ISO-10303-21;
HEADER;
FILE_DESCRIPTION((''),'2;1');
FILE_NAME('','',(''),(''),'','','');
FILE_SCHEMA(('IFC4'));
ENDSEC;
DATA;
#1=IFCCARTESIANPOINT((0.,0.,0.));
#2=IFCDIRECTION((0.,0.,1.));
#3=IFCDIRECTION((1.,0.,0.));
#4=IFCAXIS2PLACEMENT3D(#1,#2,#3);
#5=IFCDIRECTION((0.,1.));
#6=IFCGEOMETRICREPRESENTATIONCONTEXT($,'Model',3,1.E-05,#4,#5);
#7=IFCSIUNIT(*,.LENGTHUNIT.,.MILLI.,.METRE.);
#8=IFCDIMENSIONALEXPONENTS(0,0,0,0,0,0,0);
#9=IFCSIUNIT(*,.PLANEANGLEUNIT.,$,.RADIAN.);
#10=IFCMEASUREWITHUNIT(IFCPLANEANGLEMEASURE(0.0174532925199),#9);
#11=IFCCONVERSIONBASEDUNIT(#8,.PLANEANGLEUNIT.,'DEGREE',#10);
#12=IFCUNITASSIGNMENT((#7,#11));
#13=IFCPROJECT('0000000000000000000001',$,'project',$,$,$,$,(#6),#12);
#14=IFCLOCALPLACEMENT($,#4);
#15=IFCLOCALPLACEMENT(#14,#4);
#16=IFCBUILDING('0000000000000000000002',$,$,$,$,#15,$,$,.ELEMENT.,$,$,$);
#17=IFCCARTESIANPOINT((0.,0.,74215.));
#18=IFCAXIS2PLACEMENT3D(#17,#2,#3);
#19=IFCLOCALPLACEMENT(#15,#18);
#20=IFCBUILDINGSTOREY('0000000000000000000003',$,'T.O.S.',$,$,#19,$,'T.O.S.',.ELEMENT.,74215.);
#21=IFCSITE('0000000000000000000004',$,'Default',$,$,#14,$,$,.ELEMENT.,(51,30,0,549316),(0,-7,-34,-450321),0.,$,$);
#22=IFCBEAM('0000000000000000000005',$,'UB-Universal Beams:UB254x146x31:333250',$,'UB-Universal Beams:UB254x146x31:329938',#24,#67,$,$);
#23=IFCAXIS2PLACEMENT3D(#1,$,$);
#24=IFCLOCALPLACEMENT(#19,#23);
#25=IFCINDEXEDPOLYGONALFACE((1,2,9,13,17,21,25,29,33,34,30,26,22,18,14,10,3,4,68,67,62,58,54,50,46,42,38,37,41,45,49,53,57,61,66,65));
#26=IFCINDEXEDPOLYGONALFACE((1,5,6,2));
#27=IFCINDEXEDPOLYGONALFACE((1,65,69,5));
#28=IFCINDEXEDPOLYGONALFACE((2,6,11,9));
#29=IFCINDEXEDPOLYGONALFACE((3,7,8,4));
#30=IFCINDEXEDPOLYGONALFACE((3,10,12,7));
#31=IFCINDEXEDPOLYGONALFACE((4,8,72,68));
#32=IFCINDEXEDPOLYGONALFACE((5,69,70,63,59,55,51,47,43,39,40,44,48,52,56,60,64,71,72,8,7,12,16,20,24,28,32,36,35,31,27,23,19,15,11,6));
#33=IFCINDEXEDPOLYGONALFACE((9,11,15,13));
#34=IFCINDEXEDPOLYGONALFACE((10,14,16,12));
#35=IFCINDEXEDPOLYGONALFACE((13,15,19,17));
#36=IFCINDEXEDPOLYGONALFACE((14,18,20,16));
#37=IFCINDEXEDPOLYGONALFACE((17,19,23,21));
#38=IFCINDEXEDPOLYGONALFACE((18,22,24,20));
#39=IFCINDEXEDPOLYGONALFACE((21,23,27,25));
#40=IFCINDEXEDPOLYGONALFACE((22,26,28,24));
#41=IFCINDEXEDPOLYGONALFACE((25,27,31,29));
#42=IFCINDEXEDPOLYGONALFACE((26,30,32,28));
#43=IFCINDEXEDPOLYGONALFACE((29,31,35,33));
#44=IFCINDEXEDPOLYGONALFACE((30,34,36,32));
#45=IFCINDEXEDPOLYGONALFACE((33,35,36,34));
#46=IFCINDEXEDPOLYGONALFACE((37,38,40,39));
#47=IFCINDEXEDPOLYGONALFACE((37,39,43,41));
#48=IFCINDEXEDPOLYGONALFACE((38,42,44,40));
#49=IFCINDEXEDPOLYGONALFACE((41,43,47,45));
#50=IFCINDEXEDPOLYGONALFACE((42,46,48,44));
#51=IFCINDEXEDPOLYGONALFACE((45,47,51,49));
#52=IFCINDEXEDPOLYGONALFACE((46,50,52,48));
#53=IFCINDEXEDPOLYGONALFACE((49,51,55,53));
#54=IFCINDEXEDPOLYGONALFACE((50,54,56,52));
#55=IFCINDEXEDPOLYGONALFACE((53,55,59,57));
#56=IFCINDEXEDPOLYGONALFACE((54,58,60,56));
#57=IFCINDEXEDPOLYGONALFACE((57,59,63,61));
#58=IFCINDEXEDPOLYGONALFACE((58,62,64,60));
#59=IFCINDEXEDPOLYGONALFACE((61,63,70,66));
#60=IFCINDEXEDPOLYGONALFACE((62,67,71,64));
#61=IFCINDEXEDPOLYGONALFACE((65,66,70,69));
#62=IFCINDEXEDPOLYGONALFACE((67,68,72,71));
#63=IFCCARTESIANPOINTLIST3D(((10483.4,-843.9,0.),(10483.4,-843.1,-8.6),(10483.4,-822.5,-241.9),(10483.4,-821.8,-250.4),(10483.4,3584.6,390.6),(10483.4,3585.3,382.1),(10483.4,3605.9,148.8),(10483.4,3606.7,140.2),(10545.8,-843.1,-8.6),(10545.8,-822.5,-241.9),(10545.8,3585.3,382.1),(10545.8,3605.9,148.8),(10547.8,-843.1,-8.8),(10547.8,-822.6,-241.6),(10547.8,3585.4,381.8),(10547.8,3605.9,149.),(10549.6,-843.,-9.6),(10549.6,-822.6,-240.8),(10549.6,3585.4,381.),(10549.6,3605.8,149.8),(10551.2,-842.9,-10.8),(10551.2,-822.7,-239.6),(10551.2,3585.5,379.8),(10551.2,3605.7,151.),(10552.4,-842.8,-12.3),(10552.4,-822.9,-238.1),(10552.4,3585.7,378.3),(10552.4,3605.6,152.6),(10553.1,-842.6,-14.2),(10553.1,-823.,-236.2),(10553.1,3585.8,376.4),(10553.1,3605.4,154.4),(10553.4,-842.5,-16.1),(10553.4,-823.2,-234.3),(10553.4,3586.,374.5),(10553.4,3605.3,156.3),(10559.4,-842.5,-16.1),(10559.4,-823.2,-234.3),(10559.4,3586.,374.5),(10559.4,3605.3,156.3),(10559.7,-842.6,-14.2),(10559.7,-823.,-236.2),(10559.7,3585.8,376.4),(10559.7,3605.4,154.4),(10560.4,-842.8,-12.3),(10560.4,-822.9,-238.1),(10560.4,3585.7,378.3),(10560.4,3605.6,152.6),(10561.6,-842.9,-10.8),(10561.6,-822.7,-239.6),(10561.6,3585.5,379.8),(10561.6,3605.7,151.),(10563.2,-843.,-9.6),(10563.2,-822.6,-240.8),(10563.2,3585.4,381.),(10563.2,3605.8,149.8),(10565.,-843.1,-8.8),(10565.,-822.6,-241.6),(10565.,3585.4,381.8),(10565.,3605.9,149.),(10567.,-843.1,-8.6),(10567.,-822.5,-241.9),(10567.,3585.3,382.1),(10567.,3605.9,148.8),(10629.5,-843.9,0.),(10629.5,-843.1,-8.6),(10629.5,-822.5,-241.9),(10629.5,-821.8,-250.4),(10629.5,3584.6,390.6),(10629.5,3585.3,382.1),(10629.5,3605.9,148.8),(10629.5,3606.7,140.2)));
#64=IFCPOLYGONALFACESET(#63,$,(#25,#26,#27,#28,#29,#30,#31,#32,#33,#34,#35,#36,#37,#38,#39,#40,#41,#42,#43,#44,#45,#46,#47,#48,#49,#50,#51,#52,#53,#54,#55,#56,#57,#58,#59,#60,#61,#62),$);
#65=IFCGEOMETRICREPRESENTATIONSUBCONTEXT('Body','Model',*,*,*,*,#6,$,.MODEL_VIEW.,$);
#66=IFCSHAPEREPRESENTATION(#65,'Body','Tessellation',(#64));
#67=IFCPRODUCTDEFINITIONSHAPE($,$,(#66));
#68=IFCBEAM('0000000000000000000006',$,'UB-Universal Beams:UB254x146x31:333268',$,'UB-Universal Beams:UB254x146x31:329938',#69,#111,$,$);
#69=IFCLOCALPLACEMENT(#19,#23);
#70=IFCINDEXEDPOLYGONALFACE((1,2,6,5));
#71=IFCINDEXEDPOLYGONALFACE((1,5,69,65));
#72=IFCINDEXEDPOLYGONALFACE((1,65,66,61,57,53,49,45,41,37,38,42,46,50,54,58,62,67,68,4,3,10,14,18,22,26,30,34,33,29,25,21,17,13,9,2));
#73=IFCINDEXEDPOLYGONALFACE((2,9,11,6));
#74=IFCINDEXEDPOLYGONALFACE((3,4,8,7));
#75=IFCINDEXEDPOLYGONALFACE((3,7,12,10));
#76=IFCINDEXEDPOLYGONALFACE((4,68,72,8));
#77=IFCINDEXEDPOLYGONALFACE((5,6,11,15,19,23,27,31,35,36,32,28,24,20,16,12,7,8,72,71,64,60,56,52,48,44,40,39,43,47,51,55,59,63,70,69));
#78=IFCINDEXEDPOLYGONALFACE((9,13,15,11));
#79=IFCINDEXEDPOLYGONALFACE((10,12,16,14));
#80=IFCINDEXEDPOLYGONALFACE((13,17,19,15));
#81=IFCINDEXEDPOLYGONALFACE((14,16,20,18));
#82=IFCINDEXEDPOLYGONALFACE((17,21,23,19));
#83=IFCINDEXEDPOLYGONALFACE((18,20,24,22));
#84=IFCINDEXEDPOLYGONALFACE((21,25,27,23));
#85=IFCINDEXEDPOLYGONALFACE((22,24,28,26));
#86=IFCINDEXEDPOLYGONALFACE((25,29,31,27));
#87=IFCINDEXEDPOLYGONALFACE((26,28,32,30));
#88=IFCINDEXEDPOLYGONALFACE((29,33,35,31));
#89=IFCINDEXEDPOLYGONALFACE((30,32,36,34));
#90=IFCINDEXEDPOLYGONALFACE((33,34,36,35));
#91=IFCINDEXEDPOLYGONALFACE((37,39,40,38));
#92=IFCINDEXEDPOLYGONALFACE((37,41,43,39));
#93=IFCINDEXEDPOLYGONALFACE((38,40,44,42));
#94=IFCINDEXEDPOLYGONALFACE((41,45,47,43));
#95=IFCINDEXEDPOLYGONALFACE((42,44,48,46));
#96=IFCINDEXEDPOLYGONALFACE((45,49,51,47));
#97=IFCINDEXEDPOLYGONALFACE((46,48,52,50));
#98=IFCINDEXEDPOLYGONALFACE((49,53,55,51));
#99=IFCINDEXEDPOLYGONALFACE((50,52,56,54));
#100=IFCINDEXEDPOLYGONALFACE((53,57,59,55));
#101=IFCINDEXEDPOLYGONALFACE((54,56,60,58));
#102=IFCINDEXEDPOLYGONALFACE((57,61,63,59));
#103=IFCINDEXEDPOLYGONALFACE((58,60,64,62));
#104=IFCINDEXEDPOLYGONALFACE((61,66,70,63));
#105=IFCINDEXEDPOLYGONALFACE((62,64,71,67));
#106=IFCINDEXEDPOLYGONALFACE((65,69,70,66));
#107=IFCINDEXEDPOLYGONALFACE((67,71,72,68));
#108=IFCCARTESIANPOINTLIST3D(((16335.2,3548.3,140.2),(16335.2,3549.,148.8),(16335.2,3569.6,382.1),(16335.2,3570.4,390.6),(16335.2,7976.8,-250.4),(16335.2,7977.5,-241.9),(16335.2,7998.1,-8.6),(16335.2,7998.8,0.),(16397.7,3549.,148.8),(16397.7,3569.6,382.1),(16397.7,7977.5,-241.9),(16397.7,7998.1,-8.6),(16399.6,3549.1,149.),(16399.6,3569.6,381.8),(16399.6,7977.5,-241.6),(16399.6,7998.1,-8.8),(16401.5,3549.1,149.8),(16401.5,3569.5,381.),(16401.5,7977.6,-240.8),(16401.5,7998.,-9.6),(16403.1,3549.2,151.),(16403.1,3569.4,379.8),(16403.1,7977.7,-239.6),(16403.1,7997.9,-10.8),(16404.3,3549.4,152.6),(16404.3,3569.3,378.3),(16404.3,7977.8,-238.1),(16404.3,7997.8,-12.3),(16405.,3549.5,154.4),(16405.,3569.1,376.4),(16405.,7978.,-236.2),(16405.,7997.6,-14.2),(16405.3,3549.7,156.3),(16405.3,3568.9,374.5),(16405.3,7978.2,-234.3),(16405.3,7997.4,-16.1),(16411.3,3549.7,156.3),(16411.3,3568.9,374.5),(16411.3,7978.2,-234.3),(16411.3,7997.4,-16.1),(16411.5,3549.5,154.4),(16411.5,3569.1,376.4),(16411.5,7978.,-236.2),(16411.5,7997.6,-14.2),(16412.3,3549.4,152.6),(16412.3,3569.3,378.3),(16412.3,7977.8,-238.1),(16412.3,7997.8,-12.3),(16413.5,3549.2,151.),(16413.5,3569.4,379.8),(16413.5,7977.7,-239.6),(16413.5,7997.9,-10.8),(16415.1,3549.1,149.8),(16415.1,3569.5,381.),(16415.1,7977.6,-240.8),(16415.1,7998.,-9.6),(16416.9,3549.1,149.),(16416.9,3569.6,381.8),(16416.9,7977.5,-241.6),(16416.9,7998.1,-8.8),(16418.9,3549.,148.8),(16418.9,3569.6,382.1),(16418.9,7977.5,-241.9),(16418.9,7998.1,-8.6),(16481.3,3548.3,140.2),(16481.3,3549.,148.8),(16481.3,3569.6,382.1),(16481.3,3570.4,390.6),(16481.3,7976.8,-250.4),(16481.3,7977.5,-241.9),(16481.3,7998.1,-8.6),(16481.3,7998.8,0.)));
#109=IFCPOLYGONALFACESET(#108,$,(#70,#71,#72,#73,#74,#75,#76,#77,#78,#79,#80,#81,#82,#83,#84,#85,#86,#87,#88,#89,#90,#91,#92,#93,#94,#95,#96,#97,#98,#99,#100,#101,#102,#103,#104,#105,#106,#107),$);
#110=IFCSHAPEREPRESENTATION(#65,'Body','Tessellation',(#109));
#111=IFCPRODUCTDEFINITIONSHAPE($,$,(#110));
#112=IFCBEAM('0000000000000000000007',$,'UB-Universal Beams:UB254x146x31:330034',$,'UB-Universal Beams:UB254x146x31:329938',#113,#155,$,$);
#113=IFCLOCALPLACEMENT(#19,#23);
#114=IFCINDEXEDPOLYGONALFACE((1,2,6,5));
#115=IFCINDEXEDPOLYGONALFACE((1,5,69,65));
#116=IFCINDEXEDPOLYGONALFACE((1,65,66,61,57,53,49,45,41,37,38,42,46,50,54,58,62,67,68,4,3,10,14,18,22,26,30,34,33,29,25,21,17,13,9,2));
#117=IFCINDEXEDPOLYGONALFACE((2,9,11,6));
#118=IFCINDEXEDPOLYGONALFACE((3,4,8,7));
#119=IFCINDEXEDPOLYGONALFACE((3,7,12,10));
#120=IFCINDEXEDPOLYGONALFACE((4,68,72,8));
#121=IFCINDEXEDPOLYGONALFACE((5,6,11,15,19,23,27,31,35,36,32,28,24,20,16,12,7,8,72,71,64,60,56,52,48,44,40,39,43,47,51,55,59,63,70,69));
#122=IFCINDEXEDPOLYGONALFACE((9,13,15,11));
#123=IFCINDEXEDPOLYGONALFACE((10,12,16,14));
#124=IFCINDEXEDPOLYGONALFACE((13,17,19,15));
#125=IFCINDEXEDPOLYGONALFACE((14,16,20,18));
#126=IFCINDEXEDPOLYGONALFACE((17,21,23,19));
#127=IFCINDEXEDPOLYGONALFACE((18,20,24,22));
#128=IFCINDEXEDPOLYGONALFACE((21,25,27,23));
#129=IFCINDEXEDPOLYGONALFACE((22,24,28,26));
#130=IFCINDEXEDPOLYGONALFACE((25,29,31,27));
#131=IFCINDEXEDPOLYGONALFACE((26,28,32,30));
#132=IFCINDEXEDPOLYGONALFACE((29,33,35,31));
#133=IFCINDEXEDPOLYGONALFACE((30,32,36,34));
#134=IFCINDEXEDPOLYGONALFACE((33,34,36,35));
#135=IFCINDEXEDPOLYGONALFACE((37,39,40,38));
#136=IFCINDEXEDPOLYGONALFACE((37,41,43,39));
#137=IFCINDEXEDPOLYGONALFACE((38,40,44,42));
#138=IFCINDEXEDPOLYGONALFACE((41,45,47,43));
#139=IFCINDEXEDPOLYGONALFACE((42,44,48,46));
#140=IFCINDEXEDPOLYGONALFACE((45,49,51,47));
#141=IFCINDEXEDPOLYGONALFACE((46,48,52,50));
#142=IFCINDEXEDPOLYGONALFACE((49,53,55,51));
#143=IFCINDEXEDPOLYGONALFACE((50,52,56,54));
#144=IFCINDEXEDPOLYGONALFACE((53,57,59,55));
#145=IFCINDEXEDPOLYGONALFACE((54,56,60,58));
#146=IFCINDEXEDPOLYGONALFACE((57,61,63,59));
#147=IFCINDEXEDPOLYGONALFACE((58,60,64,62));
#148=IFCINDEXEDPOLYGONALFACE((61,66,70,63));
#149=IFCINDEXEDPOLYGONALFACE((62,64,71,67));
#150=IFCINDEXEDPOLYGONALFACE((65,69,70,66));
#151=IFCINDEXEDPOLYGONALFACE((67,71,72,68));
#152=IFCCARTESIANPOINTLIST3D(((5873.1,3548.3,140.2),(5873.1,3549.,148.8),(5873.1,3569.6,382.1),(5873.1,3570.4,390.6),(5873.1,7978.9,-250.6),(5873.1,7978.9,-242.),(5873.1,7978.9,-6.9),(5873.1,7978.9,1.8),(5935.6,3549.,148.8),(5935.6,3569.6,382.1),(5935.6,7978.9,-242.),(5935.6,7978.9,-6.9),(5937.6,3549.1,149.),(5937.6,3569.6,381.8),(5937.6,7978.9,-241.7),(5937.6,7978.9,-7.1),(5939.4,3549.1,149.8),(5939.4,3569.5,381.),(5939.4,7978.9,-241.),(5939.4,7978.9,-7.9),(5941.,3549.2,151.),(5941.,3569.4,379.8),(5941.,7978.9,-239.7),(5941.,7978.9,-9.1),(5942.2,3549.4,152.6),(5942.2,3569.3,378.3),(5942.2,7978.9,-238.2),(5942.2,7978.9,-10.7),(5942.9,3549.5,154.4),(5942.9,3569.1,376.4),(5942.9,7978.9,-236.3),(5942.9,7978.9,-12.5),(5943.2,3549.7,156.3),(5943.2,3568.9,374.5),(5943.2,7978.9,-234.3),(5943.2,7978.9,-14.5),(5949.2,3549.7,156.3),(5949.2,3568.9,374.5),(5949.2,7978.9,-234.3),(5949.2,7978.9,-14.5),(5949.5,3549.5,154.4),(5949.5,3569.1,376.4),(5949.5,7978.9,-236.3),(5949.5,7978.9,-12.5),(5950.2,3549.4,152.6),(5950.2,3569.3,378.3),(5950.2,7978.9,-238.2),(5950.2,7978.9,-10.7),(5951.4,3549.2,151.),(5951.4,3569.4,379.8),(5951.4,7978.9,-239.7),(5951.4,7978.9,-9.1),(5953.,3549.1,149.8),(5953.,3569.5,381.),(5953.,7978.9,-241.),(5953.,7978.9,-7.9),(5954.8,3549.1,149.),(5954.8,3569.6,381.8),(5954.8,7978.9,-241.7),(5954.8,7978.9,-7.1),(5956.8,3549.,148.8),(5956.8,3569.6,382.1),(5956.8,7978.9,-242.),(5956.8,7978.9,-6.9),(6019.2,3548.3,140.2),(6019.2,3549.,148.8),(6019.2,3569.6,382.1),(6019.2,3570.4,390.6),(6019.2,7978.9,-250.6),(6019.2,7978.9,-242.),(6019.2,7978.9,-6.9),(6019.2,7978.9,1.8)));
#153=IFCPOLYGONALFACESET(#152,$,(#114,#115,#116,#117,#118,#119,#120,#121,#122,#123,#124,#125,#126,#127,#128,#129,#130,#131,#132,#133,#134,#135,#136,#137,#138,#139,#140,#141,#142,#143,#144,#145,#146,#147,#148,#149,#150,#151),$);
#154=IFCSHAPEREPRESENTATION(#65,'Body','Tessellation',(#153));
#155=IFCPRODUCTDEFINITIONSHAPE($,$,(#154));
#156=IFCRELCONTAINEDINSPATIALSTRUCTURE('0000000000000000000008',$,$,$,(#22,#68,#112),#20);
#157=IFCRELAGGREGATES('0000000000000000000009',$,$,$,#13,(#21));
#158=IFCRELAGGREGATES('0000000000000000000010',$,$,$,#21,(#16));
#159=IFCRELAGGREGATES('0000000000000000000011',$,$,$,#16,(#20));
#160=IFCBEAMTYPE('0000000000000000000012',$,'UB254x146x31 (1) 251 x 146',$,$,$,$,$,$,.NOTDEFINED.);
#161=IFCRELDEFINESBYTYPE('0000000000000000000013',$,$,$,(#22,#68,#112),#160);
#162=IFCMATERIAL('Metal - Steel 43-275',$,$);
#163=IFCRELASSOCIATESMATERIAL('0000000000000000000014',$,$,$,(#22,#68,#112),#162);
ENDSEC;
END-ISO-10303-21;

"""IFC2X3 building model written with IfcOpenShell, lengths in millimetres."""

from ifc_helpers import new_model, entity, si_unit, converted_unit, point, direction, frame, frame_2d, origin_with_axes, place, context, subcontext, project, spatial, polyline, circle_curve, parameter, trimmed, segment, composite_curve, outline, extrude, clip, halfspace, material, type_object, element, save


model = new_model("IFC2X3")

# Units and contexts
model_context = context("Model", 3, precision=1e-05, world=origin_with_axes(), true_north=direction((0.0, 1.0)))
body_context = subcontext(model_context, "Body", "Model", "MODEL_VIEW")
ifc_project = project(units=[si_unit("LENGTHUNIT", "METRE", prefix="MILLI"), converted_unit("PLANEANGLEUNIT", "DEGREE", entity("IfcPlaneAngleMeasure", 0.0174532925199), si_unit("PLANEANGLEUNIT", "RADIAN"), dimensions=[0, 0, 0, 0, 0, 0, 0])], contexts=[model_context])

# Site, building, storey
site_placement = place(None, origin_with_axes())
site = spatial("IfcSite", under=ifc_project, at=site_placement, Name="Default", CompositionType="ELEMENT", RefLatitude=(51, 30, 0, 549316), RefLongitude=(0, -7, -34, -450321), RefElevation=0.0)
building_placement = place(site_placement, origin_with_axes())
building = spatial("IfcBuilding", under=site, at=building_placement, CompositionType="ELEMENT")
storey_placement = place(building_placement, frame((0.0, 0.0, 74215.0), z_axis=(0.0, 0.0, 1.0), x_axis=(1.0, 0.0, 0.0)))
storey = spatial("IfcBuildingStorey", under=building, at=storey_placement, Name="T.O.S.", LongName="T.O.S.", CompositionType="ELEMENT", Elevation=74215.0)

# Beams
ifc_material = material(Name="Metal - Steel 43-275")
beam_type_1 = type_object("IfcBeamType", Name="UB254x146x31 (1) 251 x 146", PredefinedType="NOTDEFINED")
beam_1_placement = place(storey_placement, frame((10556.4, 3613.8, 267.0), z_axis=(0.0, 0.0, 1.0), x_axis=(-1.0, 0.0, 0.0)))
element("IfcBeam", 1, at=beam_1_placement, inside=storey, type_object=beam_type_1, material=ifc_material, Name="UB-Universal Beams:UB254x146x31:333250", ObjectType="UB-Universal Beams:UB254x146x31:329938", context=body_context, shape_type="Clipping", body=[
    clip(clip(clip(clip(extrude(outline(composite_curve([segment(polyline([(125.7, 73.0), (117.1, 73.0), (117.1, 10.6)]), True, "CONTINUOUS"), segment(trimmed(circle_curve(frame_2d((109.5, 10.6), x_axis=(0.0, -1.0)), 7.6), [point((117.1, 10.6)), parameter(90.0)], [point((109.5, 3.0)), parameter(0.0)], False, "CARTESIAN"), True, "CONTINUOUS"), segment(polyline([(109.5, 3.0), (-109.5, 3.0)]), True, "CONTINUOUS"), segment(trimmed(circle_curve(frame_2d((-109.5, 10.6), x_axis=(-1.0, 0.0)), 7.6), [point((-109.5, 3.0)), parameter(90.0)], [point((-117.1, 10.6)), parameter(0.0)], False, "CARTESIAN"), True, "CONTINUOUS"), segment(polyline([(-117.1, 10.6), (-117.1, 73.0), (-125.7, 73.0), (-125.7, -73.0), (-117.1, -73.0), (-117.1, -10.6)]), True, "CONTINUOUS"), segment(trimmed(circle_curve(frame_2d((-109.5, -10.6), x_axis=(0.0, 1.0)), 7.6), [point((-117.1, -10.6)), parameter(90.0)], [point((-109.5, -3.0)), parameter(0.0)], False, "CARTESIAN"), True, "CONTINUOUS"), segment(polyline([(-109.5, -3.0), (109.5, -3.0)]), True, "CONTINUOUS"), segment(trimmed(circle_curve(frame_2d((109.5, -10.6), x_axis=(1.0, 0.0)), 7.6), [point((109.5, -3.0)), parameter(90.0)], [point((117.1, -10.6)), parameter(0.0)], False, "CARTESIAN"), True, "CONTINUOUS"), segment(polyline([(117.1, -10.6), (117.1, -73.0), (125.7, -73.0), (125.7, 73.0)]), True, "CONTINUOUS")], self_intersect=False)), frame((0.0, 4482.9, -395.4), z_axis=(0.0, -0.996132, 0.087866), x_axis=(0.0, -0.087866, -0.996132)), (0.0, 0.0, 1.0), 4518.6), halfspace(frame((0.0, 4446.6, -392.2), z_axis=(0.0, -0.996132, 0.087866), x_axis=(0.0, -0.087866, -0.996132)), True)), halfspace(frame((0.0, 18.2, -1.6), z_axis=(0.0, 0.996132, -0.087866), x_axis=(0.0, 0.087866, 0.996132)), True)), halfspace(frame((0.0, 4464.8, 0.0), z_axis=(0.0, -1.0, 0.0), x_axis=(0.0, 0.0, -1.0)), True)), halfspace(frame((0.0, 0.0, 0.0), z_axis=(0.0, 1.0, 0.0), x_axis=(0.0, 0.0, 1.0)), True)),
])
beam_2_placement = place(storey_placement, frame((16408.3, 3541.2, 267.0), z_axis=(0.0, 0.0, 1.0), x_axis=(1.0, 0.0, 0.0)))
element("IfcBeam", 2, at=beam_2_placement, inside=storey, type_object=beam_type_1, material=ifc_material, Name="UB-Universal Beams:UB254x146x31:333268", ObjectType="UB-Universal Beams:UB254x146x31:329938", context=body_context, shape_type="Clipping", body=[
    clip(clip(clip(clip(extrude(outline(composite_curve([segment(polyline([(125.7, 73.0), (117.1, 73.0), (117.1, 10.6)]), True, "CONTINUOUS"), segment(trimmed(circle_curve(frame_2d((109.5, 10.6), x_axis=(0.0, -1.0)), 7.6), [point((117.1, 10.6)), parameter(90.0)], [point((109.5, 3.0)), parameter(0.0)], False, "CARTESIAN"), True, "CONTINUOUS"), segment(polyline([(109.5, 3.0), (-109.5, 3.0)]), True, "CONTINUOUS"), segment(trimmed(circle_curve(frame_2d((-109.5, 10.6), x_axis=(-1.0, 0.0)), 7.6), [point((-109.5, 3.0)), parameter(90.0)], [point((-117.1, 10.6)), parameter(0.0)], False, "CARTESIAN"), True, "CONTINUOUS"), segment(polyline([(-117.1, 10.6), (-117.1, 73.0), (-125.7, 73.0), (-125.7, -73.0), (-117.1, -73.0), (-117.1, -10.6)]), True, "CONTINUOUS"), segment(trimmed(circle_curve(frame_2d((-109.5, -10.6), x_axis=(0.0, 1.0)), 7.6), [point((-117.1, -10.6)), parameter(90.0)], [point((-109.5, -3.0)), parameter(0.0)], False, "CARTESIAN"), True, "CONTINUOUS"), segment(polyline([(-109.5, -3.0), (109.5, -3.0)]), True, "CONTINUOUS"), segment(trimmed(circle_curve(frame_2d((109.5, -10.6), x_axis=(1.0, 0.0)), 7.6), [point((109.5, -3.0)), parameter(90.0)], [point((117.1, -10.6)), parameter(0.0)], False, "CARTESIAN"), True, "CONTINUOUS"), segment(polyline([(117.1, -10.6), (117.1, -73.0), (125.7, -73.0), (125.7, 73.0)]), True, "CONTINUOUS")], self_intersect=False)), frame((0.0, 4482.9, -395.4), z_axis=(0.0, -0.996132, 0.087866), x_axis=(0.0, -0.087866, -0.996132)), (0.0, 0.0, 1.0), 4518.6), halfspace(frame((0.0, 4446.6, -392.2), z_axis=(0.0, -0.996132, 0.087866), x_axis=(0.0, -0.087866, -0.996132)), True)), halfspace(frame((0.0, 18.2, -1.6), z_axis=(0.0, 0.996132, -0.087866), x_axis=(0.0, 0.087866, 0.996132)), True)), halfspace(frame((0.0, 4464.8, 0.0), z_axis=(0.0, -1.0, 0.0), x_axis=(0.0, 0.0, -1.0)), True)), halfspace(frame((0.0, 0.0, 0.0), z_axis=(0.0, 1.0, 0.0), x_axis=(0.0, 0.0, 1.0)), True)),
])
beam_3_placement = place(storey_placement, frame((5946.2, 3541.2, 267.0), z_axis=(0.0, 0.0, 1.0), x_axis=(1.0, 0.0, 0.0)))
element("IfcBeam", 3, at=beam_3_placement, inside=storey, type_object=beam_type_1, material=ifc_material, Name="UB-Universal Beams:UB254x146x31:330034", ObjectType="UB-Universal Beams:UB254x146x31:329938", context=body_context, shape_type="Clipping", body=[
    clip(clip(clip(extrude(outline(composite_curve([segment(polyline([(125.7, 73.0), (117.1, 73.0), (117.1, 10.6)]), True, "CONTINUOUS"), segment(trimmed(circle_curve(frame_2d((109.5, 10.6), x_axis=(0.0, -1.0)), 7.6), [point((117.1, 10.6)), parameter(90.0)], [point((109.5, 3.0)), parameter(0.0)], False, "CARTESIAN"), True, "CONTINUOUS"), segment(polyline([(109.5, 3.0), (-109.5, 3.0)]), True, "CONTINUOUS"), segment(trimmed(circle_curve(frame_2d((-109.5, 10.6), x_axis=(-1.0, 0.0)), 7.6), [point((-109.5, 3.0)), parameter(90.0)], [point((-117.1, 10.6)), parameter(0.0)], False, "CARTESIAN"), True, "CONTINUOUS"), segment(polyline([(-117.1, 10.6), (-117.1, 73.0), (-125.7, 73.0), (-125.7, -73.0), (-117.1, -73.0), (-117.1, -10.6)]), True, "CONTINUOUS"), segment(trimmed(circle_curve(frame_2d((-109.5, -10.6), x_axis=(0.0, 1.0)), 7.6), [point((-117.1, -10.6)), parameter(90.0)], [point((-109.5, -3.0)), parameter(0.0)], False, "CARTESIAN"), True, "CONTINUOUS"), segment(polyline([(-109.5, -3.0), (109.5, -3.0)]), True, "CONTINUOUS"), segment(trimmed(circle_curve(frame_2d((109.5, -10.6), x_axis=(1.0, 0.0)), 7.6), [point((109.5, -3.0)), parameter(90.0)], [point((117.1, -10.6)), parameter(0.0)], False, "CARTESIAN"), True, "CONTINUOUS"), segment(polyline([(117.1, -10.6), (117.1, -73.0), (125.7, -73.0), (125.7, 73.0)]), True, "CONTINUOUS")], self_intersect=False)), frame((0.0, 4455.9, -393.0), z_axis=(0.0, -0.996132, 0.087866), x_axis=(0.0, -0.087866, -0.996132)), (0.0, 0.0, 1.0), 4491.4), halfspace(frame((0.0, 18.2, -1.6), z_axis=(0.0, 0.996132, -0.087866), x_axis=(0.0, 0.087866, 0.996132)), True)), halfspace(frame((0.0, 4437.7, 0.0), z_axis=(0.0, -1.0, 0.0), x_axis=(0.0, 0.0, -1.0)), True)), halfspace(frame((0.0, 0.0, 0.0), z_axis=(0.0, 1.0, 0.0), x_axis=(0.0, 0.0, 1.0)), True)),
])

save(model, "model.ifc")
